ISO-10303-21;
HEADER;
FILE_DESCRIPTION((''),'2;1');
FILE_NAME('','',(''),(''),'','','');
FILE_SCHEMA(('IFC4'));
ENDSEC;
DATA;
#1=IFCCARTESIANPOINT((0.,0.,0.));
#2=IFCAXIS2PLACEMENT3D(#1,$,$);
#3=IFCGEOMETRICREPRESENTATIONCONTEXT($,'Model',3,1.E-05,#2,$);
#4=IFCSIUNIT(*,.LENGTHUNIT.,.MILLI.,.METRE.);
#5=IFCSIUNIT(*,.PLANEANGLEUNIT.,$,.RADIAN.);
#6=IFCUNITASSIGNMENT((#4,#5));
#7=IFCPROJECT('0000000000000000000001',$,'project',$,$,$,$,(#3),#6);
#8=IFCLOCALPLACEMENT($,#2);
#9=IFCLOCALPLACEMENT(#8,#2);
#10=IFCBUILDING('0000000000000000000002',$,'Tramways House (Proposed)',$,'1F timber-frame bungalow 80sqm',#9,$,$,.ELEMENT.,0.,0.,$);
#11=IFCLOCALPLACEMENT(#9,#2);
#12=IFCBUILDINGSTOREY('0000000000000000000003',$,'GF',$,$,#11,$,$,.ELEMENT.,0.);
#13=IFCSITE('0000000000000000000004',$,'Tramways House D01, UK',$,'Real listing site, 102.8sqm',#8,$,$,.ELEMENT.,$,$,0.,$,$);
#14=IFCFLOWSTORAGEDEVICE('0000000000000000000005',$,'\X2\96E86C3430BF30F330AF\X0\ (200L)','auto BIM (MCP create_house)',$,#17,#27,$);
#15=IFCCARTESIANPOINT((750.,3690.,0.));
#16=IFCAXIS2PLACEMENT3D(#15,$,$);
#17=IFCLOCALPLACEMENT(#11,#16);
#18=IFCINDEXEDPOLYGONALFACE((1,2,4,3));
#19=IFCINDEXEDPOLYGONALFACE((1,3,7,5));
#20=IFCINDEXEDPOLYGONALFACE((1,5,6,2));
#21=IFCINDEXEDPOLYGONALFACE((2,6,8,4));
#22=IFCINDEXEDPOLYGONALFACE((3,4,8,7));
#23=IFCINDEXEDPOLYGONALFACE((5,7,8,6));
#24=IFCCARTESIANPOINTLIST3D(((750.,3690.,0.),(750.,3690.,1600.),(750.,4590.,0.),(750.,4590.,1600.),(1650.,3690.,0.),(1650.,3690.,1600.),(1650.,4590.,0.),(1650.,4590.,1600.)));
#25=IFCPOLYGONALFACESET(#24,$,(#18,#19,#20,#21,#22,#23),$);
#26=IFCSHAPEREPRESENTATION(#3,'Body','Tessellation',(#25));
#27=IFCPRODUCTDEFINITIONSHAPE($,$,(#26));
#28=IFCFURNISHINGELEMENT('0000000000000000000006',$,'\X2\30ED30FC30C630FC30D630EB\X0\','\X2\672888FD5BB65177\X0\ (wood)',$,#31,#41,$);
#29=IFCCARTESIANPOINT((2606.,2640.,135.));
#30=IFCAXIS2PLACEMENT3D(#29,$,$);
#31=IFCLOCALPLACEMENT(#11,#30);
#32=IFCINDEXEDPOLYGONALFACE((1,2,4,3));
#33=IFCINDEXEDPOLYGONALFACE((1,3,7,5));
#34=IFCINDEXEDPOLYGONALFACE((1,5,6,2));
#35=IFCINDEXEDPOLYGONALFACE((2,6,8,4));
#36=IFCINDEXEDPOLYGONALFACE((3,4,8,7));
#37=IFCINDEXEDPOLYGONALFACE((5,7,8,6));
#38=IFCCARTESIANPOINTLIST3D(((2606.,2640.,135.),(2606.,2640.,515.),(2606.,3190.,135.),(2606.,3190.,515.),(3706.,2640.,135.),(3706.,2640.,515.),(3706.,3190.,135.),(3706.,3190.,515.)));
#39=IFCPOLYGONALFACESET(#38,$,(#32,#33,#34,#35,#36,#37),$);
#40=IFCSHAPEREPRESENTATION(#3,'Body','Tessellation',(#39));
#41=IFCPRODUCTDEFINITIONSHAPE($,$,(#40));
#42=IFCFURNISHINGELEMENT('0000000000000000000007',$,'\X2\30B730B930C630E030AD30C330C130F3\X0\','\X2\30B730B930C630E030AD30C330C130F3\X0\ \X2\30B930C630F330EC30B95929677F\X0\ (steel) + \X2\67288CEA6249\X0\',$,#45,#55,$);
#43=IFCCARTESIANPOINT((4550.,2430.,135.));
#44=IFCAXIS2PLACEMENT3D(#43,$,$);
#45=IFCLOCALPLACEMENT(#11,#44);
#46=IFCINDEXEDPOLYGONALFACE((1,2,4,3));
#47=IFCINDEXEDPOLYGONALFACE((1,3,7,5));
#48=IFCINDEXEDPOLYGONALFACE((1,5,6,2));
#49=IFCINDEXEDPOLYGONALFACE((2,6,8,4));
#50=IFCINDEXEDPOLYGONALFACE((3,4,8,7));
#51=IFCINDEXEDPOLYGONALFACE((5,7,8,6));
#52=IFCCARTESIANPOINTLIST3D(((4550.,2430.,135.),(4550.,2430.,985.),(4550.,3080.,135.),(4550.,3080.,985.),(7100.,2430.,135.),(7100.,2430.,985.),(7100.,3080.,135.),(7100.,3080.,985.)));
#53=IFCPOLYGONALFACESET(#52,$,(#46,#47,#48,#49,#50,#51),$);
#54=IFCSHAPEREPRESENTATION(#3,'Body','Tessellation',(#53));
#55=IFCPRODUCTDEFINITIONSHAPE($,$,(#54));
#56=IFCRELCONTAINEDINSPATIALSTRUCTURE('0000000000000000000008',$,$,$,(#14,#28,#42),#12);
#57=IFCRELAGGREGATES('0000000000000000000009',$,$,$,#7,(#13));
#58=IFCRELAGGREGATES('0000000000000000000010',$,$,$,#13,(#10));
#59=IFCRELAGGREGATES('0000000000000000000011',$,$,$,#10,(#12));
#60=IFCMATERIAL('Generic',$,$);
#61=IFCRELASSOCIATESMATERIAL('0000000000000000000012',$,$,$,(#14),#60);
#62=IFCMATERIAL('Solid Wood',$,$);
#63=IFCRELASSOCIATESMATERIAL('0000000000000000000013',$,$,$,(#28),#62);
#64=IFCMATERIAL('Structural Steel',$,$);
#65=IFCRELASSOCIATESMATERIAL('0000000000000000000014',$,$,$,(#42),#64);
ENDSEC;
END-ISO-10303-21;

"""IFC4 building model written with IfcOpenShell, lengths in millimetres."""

from ifc_helpers import new_model, si_unit, frame, frame_2d, origin, place, context, project, spatial, rectangle, extrude, material, element, save


model = new_model("IFC4")

# Units and contexts
model_context = context("Model", 3, precision=1e-05, world=origin())
ifc_project = project(units=[si_unit("LENGTHUNIT", "METRE", prefix="MILLI"), si_unit("PLANEANGLEUNIT", "RADIAN")], contexts=[model_context])

# Site, building, storey
site_placement = place(None, origin())
site = spatial("IfcSite", under=ifc_project, at=site_placement, Name="Tramways House D01, UK", ObjectType="Real listing site, 102.8sqm", CompositionType="ELEMENT", RefElevation=0.0)
building_placement = place(site_placement, origin())
building = spatial("IfcBuilding", under=site, at=building_placement, Name="Tramways House (Proposed)", ObjectType="1F timber-frame bungalow 80sqm", CompositionType="ELEMENT", ElevationOfRefHeight=0.0, ElevationOfTerrain=0.0)
storey_placement = place(building_placement, origin())
storey = spatial("IfcBuildingStorey", under=building, at=storey_placement, Name="GF", CompositionType="ELEMENT", Elevation=0.0)

# Shared definitions
ifc_material_1 = material(Name="Solid Wood")

# Shared definitions
ifc_material_2 = material(Name="Generic")

# Flow storage device
flow_storage_device_placement = place(storey_placement, frame((750.0, 3690.0, 0.0)))
element("IfcFlowStorageDevice", 1, at=flow_storage_device_placement, inside=storey, material=ifc_material_2, Name="雨水タンク (200L)", Description="auto BIM (MCP create_house)", context=model_context, shape_type="SweptSolid", body=[
    extrude(rectangle(XDim=900.0, YDim=900.0, at=frame_2d((450.0, 450.0))), frame((750.0, 3690.0, 0.0)), (0.0, 0.0, 1.0), 1600.0),
])

# Furnishing elements
furnishing_1_placement = place(storey_placement, frame((2606.0, 2640.0, 135.0)))
element("IfcFurnishingElement", 2, at=furnishing_1_placement, inside=storey, material=ifc_material_1, Name="ローテーブル", Description="木製家具 (wood)", context=model_context, shape_type="SweptSolid", body=[
    extrude(rectangle(XDim=1100.0, YDim=550.0, at=frame_2d((550.0, 275.0))), frame((2606.0, 2640.0, 135.0)), (0.0, 0.0, 1.0), 380.0),
])
ifc_material_3 = material(Name="Structural Steel")
furnishing_2_placement = place(storey_placement, frame((4550.0, 2430.0, 135.0)))
element("IfcFurnishingElement", 3, at=furnishing_2_placement, inside=storey, material=ifc_material_3, Name="システムキッチン", Description="システムキッチン ステンレス天板 (steel) + 木質扉", context=model_context, shape_type="SweptSolid", body=[
    extrude(rectangle(XDim=2550.0, YDim=650.0, at=frame_2d((1275.0, 325.0))), frame((4550.0, 2430.0, 135.0)), (0.0, 0.0, 1.0), 850.0),
])

save(model, "model.ifc")
